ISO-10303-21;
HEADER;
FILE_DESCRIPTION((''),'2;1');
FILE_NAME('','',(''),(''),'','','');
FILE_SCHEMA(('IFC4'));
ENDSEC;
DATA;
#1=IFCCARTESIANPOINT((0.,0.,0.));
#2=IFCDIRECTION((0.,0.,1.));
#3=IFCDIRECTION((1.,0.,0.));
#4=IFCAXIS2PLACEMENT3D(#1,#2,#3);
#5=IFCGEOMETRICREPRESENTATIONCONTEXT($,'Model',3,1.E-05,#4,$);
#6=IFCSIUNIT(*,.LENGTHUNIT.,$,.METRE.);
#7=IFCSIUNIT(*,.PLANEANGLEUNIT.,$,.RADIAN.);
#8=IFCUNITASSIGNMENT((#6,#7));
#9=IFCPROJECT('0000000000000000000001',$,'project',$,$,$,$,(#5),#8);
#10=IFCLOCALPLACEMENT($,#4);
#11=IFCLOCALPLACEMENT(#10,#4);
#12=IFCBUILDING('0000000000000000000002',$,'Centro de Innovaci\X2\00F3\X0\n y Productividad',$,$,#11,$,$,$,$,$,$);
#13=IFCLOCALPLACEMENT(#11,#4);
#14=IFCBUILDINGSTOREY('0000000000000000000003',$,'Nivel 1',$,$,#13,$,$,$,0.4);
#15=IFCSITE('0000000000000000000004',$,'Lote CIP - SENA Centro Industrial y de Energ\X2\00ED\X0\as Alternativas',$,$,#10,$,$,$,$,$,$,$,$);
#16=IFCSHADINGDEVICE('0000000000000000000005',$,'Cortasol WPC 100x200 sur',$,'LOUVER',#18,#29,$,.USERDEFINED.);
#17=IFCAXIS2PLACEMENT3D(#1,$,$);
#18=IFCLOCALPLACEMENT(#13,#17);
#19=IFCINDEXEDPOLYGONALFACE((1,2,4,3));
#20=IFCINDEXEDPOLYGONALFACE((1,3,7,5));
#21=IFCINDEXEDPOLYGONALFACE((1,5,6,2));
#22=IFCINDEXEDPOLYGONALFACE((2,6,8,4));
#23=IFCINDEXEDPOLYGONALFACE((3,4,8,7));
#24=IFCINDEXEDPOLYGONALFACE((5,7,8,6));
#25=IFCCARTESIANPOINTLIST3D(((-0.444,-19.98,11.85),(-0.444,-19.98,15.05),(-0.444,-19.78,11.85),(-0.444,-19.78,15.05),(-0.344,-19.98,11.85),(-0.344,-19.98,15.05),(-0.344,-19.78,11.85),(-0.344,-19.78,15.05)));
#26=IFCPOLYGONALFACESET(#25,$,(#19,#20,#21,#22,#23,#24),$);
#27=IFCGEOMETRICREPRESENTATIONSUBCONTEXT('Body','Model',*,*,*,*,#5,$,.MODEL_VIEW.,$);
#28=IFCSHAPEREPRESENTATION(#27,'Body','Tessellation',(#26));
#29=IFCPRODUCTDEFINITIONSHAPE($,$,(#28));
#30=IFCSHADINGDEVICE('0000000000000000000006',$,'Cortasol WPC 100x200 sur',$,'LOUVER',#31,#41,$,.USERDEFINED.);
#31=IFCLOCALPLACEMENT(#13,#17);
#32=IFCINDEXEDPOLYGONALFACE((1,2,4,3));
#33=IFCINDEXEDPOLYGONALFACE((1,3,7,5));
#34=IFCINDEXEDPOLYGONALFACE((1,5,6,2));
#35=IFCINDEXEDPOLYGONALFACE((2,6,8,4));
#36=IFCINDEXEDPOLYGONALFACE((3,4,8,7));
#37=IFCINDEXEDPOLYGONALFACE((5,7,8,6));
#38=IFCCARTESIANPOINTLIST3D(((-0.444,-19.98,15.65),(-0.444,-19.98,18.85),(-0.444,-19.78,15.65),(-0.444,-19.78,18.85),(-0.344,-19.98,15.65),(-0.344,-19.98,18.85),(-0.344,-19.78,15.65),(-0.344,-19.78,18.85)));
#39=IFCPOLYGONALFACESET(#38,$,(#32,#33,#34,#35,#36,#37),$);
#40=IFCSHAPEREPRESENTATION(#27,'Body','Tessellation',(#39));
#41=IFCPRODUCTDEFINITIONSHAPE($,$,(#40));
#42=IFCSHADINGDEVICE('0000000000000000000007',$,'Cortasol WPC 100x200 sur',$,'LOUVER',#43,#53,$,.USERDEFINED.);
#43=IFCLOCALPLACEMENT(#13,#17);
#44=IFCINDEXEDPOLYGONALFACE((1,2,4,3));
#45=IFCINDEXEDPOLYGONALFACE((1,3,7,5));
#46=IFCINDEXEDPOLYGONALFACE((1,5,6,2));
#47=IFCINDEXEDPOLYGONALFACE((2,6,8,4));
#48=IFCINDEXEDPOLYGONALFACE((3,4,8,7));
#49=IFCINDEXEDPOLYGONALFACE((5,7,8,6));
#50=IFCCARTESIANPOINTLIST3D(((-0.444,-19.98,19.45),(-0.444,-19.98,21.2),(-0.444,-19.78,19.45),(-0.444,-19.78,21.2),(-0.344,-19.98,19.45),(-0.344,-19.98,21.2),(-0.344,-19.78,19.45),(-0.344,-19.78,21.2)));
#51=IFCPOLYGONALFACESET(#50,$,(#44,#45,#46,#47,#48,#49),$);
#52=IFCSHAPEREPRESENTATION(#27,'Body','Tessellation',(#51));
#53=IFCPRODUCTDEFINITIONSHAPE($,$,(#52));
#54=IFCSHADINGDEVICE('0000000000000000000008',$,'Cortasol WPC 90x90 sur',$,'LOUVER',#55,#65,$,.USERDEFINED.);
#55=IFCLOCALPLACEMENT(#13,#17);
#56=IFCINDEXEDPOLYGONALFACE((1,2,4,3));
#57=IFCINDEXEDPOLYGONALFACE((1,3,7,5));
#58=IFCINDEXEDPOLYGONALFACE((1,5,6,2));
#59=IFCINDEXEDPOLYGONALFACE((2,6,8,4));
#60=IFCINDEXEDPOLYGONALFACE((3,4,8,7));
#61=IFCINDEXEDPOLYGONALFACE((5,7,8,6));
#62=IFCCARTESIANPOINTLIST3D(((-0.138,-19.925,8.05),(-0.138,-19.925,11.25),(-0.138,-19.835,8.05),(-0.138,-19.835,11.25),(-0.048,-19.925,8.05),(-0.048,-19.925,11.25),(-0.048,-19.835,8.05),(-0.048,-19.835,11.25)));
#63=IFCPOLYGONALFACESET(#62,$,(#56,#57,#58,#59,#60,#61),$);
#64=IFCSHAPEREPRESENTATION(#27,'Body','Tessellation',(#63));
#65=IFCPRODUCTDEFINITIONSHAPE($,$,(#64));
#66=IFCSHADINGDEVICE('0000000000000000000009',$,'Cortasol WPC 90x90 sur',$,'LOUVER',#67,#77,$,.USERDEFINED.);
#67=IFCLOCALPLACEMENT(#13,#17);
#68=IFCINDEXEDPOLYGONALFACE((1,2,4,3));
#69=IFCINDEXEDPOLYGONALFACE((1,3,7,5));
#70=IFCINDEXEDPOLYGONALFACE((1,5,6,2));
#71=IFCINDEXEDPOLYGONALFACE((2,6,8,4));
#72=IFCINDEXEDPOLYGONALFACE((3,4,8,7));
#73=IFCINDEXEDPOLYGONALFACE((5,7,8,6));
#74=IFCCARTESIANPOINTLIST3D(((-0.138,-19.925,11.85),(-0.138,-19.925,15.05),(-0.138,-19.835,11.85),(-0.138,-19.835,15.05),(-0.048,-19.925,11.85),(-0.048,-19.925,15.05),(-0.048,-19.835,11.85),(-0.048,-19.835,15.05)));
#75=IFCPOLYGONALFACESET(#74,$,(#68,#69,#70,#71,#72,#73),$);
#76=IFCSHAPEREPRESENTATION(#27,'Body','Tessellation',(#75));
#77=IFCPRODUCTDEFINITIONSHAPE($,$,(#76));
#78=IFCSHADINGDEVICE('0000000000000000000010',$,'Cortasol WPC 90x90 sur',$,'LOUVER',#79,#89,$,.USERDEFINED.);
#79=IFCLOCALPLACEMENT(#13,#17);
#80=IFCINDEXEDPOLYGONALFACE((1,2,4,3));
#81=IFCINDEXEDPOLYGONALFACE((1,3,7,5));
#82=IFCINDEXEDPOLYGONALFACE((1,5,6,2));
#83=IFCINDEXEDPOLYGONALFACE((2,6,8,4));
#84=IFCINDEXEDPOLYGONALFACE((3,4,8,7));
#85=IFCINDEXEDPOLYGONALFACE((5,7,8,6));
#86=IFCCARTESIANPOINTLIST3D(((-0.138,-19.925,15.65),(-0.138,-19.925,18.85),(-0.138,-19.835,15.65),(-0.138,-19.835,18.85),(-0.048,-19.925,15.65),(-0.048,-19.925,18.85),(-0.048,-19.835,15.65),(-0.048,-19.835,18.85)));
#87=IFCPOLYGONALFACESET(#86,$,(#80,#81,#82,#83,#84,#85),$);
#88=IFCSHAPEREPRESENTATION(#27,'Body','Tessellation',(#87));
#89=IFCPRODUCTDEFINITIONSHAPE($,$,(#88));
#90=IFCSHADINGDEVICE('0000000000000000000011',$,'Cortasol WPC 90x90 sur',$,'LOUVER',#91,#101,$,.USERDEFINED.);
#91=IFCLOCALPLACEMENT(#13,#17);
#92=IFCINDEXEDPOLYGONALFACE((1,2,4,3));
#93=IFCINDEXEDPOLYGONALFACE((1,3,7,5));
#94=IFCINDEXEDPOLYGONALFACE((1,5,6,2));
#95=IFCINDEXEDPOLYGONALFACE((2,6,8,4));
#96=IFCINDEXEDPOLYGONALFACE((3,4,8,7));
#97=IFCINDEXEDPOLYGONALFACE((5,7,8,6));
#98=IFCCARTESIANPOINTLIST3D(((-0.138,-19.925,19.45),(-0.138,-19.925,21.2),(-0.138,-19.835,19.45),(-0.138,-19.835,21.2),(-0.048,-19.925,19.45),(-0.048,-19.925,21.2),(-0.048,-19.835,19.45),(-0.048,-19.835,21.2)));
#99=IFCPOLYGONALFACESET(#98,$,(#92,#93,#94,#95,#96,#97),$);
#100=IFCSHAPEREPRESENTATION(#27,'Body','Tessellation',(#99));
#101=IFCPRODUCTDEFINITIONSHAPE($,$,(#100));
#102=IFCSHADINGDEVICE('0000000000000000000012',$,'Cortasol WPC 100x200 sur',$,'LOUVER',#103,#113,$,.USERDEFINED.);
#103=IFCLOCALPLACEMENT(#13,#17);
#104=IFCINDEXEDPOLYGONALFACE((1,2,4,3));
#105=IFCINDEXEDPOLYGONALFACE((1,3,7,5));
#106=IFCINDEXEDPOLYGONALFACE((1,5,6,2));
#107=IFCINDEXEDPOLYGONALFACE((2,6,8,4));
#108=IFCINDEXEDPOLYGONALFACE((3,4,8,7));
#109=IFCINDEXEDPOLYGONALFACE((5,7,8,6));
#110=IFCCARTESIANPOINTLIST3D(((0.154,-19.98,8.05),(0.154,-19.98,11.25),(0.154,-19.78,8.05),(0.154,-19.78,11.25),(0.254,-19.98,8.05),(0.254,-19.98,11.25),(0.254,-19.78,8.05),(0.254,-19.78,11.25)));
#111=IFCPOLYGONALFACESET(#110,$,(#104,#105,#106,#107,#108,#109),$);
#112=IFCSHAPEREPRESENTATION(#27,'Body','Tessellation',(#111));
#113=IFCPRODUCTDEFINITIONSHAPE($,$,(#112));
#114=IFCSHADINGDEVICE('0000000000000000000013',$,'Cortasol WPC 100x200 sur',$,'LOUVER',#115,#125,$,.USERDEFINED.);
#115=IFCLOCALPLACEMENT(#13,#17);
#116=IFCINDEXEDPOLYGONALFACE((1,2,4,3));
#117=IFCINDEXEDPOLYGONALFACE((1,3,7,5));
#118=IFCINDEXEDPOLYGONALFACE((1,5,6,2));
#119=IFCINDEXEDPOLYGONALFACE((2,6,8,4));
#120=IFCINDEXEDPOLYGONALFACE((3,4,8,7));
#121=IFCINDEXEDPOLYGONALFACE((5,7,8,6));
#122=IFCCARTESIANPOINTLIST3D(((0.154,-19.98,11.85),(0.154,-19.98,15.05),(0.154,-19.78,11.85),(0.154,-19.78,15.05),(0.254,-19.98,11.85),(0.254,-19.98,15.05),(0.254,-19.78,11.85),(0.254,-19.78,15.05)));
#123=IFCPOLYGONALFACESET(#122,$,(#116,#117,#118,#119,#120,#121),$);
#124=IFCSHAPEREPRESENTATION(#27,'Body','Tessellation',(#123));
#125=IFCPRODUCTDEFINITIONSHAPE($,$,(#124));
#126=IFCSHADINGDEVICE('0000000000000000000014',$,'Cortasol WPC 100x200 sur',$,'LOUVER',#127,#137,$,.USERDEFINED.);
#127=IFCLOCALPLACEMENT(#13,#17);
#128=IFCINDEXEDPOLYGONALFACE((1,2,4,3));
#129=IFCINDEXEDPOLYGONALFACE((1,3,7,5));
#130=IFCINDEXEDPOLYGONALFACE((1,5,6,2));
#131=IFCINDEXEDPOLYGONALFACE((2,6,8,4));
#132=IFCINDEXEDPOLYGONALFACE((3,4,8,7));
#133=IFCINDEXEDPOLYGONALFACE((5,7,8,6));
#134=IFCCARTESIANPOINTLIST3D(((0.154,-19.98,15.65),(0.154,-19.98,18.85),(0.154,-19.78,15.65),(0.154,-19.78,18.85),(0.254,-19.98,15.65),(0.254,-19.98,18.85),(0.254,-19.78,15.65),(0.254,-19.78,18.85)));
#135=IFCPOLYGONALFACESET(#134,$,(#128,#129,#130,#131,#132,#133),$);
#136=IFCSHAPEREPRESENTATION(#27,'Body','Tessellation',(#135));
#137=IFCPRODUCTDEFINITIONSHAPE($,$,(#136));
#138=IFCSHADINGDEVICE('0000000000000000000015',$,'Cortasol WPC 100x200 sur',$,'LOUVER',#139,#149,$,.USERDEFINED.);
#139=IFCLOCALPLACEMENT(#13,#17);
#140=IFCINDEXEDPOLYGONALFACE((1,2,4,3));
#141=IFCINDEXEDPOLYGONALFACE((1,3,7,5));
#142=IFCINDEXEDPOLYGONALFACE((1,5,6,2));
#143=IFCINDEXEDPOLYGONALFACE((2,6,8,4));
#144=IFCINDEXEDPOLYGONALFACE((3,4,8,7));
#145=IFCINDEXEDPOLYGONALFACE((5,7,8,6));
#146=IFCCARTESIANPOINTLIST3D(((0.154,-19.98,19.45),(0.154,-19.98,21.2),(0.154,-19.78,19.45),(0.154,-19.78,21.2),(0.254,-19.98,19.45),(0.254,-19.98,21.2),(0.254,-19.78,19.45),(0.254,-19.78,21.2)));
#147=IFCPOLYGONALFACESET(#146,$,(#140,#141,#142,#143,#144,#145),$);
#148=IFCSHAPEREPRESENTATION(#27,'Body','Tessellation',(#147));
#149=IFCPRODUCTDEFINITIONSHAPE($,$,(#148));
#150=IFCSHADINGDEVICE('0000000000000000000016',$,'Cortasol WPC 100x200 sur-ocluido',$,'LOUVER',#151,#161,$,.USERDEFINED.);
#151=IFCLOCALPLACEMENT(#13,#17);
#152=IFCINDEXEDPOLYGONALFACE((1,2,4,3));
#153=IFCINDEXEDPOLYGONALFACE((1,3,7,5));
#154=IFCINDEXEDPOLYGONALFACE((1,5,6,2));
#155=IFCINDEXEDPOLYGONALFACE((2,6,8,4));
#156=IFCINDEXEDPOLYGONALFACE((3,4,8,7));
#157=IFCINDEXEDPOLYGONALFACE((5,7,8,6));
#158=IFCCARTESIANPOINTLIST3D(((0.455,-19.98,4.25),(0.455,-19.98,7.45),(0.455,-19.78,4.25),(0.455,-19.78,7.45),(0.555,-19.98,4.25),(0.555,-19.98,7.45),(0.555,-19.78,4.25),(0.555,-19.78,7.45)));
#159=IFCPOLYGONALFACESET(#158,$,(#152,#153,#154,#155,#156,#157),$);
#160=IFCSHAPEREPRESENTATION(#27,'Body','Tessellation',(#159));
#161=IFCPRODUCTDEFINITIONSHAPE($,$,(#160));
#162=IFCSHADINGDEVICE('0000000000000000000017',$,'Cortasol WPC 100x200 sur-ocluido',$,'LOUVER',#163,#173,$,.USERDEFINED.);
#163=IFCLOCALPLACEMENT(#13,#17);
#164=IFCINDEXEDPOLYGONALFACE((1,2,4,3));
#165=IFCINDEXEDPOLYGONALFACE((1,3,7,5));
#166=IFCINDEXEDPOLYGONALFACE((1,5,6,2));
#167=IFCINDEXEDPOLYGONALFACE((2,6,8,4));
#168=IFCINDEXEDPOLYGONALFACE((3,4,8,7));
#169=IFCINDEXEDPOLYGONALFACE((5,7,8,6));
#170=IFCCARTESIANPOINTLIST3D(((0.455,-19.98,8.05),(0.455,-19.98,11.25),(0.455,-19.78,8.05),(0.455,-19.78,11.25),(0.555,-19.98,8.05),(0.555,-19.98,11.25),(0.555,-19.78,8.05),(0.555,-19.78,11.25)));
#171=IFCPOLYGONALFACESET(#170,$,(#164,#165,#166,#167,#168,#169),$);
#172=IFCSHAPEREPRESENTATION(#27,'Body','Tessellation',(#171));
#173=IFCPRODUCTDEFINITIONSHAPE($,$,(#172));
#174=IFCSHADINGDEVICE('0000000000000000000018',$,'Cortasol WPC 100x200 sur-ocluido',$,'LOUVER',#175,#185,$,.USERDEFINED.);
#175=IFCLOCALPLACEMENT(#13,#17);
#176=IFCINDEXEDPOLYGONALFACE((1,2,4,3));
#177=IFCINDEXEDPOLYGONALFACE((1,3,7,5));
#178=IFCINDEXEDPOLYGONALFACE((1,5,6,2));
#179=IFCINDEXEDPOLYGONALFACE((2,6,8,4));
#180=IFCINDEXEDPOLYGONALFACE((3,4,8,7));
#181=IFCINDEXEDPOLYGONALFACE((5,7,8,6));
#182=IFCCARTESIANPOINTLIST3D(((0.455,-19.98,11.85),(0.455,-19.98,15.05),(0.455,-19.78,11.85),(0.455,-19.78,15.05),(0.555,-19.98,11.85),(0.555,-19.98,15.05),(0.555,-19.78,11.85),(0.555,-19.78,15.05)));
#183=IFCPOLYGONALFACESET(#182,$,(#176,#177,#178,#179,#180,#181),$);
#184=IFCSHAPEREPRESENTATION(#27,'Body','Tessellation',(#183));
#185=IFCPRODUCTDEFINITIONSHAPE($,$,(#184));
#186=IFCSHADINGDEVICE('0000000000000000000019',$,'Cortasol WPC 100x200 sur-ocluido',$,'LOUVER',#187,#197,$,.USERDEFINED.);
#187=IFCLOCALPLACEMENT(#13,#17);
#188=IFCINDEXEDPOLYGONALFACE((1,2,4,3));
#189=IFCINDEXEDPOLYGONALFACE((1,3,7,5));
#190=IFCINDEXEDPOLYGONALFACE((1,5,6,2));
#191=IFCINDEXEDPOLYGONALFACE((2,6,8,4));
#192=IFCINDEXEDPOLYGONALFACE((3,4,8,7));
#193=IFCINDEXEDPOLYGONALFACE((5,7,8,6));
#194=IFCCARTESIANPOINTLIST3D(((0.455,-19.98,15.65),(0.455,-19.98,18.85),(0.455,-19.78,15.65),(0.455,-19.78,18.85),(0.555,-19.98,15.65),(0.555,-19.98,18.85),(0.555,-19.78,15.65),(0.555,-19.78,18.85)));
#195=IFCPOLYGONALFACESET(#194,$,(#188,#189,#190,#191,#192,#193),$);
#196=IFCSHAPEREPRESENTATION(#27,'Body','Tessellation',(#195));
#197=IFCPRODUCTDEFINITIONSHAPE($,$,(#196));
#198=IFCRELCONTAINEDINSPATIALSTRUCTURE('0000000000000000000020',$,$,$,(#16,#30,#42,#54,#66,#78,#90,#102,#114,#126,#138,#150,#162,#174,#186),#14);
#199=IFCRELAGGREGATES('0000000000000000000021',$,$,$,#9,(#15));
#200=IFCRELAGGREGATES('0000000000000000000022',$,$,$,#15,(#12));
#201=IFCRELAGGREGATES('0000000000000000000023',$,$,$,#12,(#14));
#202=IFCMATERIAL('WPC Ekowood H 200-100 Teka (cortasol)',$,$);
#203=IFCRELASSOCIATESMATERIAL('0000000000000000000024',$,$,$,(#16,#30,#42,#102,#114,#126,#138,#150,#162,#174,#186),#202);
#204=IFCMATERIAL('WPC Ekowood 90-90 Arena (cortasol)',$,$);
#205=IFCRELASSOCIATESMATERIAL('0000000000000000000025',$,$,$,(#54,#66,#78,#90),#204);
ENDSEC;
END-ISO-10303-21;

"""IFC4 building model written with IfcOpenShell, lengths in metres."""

from ifc_helpers import new_model, si_unit, frame, origin_with_axes, place, context, subcontext, project, spatial, polyline, outline, extrude, material, element, save


model = new_model("IFC4")

# Units and contexts
model_context = context("Model", 3, precision=1e-05, world=origin_with_axes())
body_context = subcontext(model_context, "Body", "Model", "MODEL_VIEW")
ifc_project = project(units=[si_unit("LENGTHUNIT", "METRE"), si_unit("PLANEANGLEUNIT", "RADIAN")], contexts=[model_context])

# Site, building, storey
site_placement = place(None, origin_with_axes())
site = spatial("IfcSite", under=ifc_project, at=site_placement, Name="Lote CIP - SENA Centro Industrial y de Energías Alternativas")
building_placement = place(site_placement, origin_with_axes())
building = spatial("IfcBuilding", under=site, at=building_placement, Name="Centro de Innovación y Productividad")
storey_placement = place(building_placement, origin_with_axes())
storey = spatial("IfcBuildingStorey", under=building, at=storey_placement, Name="Nivel 1", Elevation=0.4)

# Shading devices
ifc_material_1 = material(Name="WPC Ekowood H 200-100 Teka (cortasol)")
shading_device_1_placement = place(storey_placement, origin_with_axes())
element("IfcShadingDevice", 1, at=shading_device_1_placement, inside=storey, material=ifc_material_1, Name="Cortasol WPC 100x200 sur", ObjectType="LOUVER", PredefinedType="USERDEFINED", context=body_context, shape_type="SweptSolid", body=[
    extrude(outline(polyline([(-0.444, -19.98), (-0.444, -19.78), (-0.344, -19.78), (-0.344, -19.98), (-0.444, -19.98)])), frame((0.0, 0.0, 11.85)), (0.0, 0.0, 1.0), 3.2),
])
shading_device_2_placement = place(storey_placement, origin_with_axes())
element("IfcShadingDevice", 2, at=shading_device_2_placement, inside=storey, material=ifc_material_1, Name="Cortasol WPC 100x200 sur", ObjectType="LOUVER", PredefinedType="USERDEFINED", context=body_context, shape_type="SweptSolid", body=[
    extrude(outline(polyline([(-0.444, -19.98), (-0.444, -19.78), (-0.344, -19.78), (-0.344, -19.98), (-0.444, -19.98)])), frame((0.0, 0.0, 15.65)), (0.0, 0.0, 1.0), 3.2),
])
shading_device_3_placement = place(storey_placement, origin_with_axes())
element("IfcShadingDevice", 3, at=shading_device_3_placement, inside=storey, material=ifc_material_1, Name="Cortasol WPC 100x200 sur", ObjectType="LOUVER", PredefinedType="USERDEFINED", context=body_context, shape_type="SweptSolid", body=[
    extrude(outline(polyline([(-0.444, -19.98), (-0.444, -19.78), (-0.344, -19.78), (-0.344, -19.98), (-0.444, -19.98)])), frame((0.0, 0.0, 19.45)), (0.0, 0.0, 1.0), 1.75),
])
ifc_material_2 = material(Name="WPC Ekowood 90-90 Arena (cortasol)")
shading_device_4_placement = place(storey_placement, origin_with_axes())
element("IfcShadingDevice", 4, at=shading_device_4_placement, inside=storey, material=ifc_material_2, Name="Cortasol WPC 90x90 sur", ObjectType="LOUVER", PredefinedType="USERDEFINED", context=body_context, shape_type="SweptSolid", body=[
    extrude(outline(polyline([(-0.138, -19.925), (-0.138, -19.835), (-0.048, -19.835), (-0.048, -19.925), (-0.138, -19.925)])), frame((0.0, 0.0, 8.05)), (0.0, 0.0, 1.0), 3.2),
])
shading_device_5_placement = place(storey_placement, origin_with_axes())
element("IfcShadingDevice", 5, at=shading_device_5_placement, inside=storey, material=ifc_material_2, Name="Cortasol WPC 90x90 sur", ObjectType="LOUVER", PredefinedType="USERDEFINED", context=body_context, shape_type="SweptSolid", body=[
    extrude(outline(polyline([(-0.138, -19.925), (-0.138, -19.835), (-0.048, -19.835), (-0.048, -19.925), (-0.138, -19.925)])), frame((0.0, 0.0, 11.85)), (0.0, 0.0, 1.0), 3.2),
])
shading_device_6_placement = place(storey_placement, origin_with_axes())
element("IfcShadingDevice", 6, at=shading_device_6_placement, inside=storey, material=ifc_material_2, Name="Cortasol WPC 90x90 sur", ObjectType="LOUVER", PredefinedType="USERDEFINED", context=body_context, shape_type="SweptSolid", body=[
    extrude(outline(polyline([(-0.138, -19.925), (-0.138, -19.835), (-0.048, -19.835), (-0.048, -19.925), (-0.138, -19.925)])), frame((0.0, 0.0, 15.65)), (0.0, 0.0, 1.0), 3.2),
])
shading_device_7_placement = place(storey_placement, origin_with_axes())
element("IfcShadingDevice", 7, at=shading_device_7_placement, inside=storey, material=ifc_material_2, Name="Cortasol WPC 90x90 sur", ObjectType="LOUVER", PredefinedType="USERDEFINED", context=body_context, shape_type="SweptSolid", body=[
    extrude(outline(polyline([(-0.138, -19.925), (-0.138, -19.835), (-0.048, -19.835), (-0.048, -19.925), (-0.138, -19.925)])), frame((0.0, 0.0, 19.45)), (0.0, 0.0, 1.0), 1.75),
])
shading_device_8_placement = place(storey_placement, origin_with_axes())
element("IfcShadingDevice", 8, at=shading_device_8_placement, inside=storey, material=ifc_material_1, Name="Cortasol WPC 100x200 sur", ObjectType="LOUVER", PredefinedType="USERDEFINED", context=body_context, shape_type="SweptSolid", body=[
    extrude(outline(polyline([(0.154, -19.98), (0.154, -19.78), (0.254, -19.78), (0.254, -19.98), (0.154, -19.98)])), frame((0.0, 0.0, 8.05)), (0.0, 0.0, 1.0), 3.2),
])
shading_device_9_placement = place(storey_placement, origin_with_axes())
element("IfcShadingDevice", 9, at=shading_device_9_placement, inside=storey, material=ifc_material_1, Name="Cortasol WPC 100x200 sur", ObjectType="LOUVER", PredefinedType="USERDEFINED", context=body_context, shape_type="SweptSolid", body=[
    extrude(outline(polyline([(0.154, -19.98), (0.154, -19.78), (0.254, -19.78), (0.254, -19.98), (0.154, -19.98)])), frame((0.0, 0.0, 11.85)), (0.0, 0.0, 1.0), 3.2),
])
shading_device_10_placement = place(storey_placement, origin_with_axes())
element("IfcShadingDevice", 10, at=shading_device_10_placement, inside=storey, material=ifc_material_1, Name="Cortasol WPC 100x200 sur", ObjectType="LOUVER", PredefinedType="USERDEFINED", context=body_context, shape_type="SweptSolid", body=[
    extrude(outline(polyline([(0.154, -19.98), (0.154, -19.78), (0.254, -19.78), (0.254, -19.98), (0.154, -19.98)])), frame((0.0, 0.0, 15.65)), (0.0, 0.0, 1.0), 3.2),
])
shading_device_11_placement = place(storey_placement, origin_with_axes())
element("IfcShadingDevice", 11, at=shading_device_11_placement, inside=storey, material=ifc_material_1, Name="Cortasol WPC 100x200 sur", ObjectType="LOUVER", PredefinedType="USERDEFINED", context=body_context, shape_type="SweptSolid", body=[
    extrude(outline(polyline([(0.154, -19.98), (0.154, -19.78), (0.254, -19.78), (0.254, -19.98), (0.154, -19.98)])), frame((0.0, 0.0, 19.45)), (0.0, 0.0, 1.0), 1.75),
])
shading_device_12_placement = place(storey_placement, origin_with_axes())
element("IfcShadingDevice", 12, at=shading_device_12_placement, inside=storey, material=ifc_material_1, Name="Cortasol WPC 100x200 sur-ocluido", ObjectType="LOUVER", PredefinedType="USERDEFINED", context=body_context, shape_type="SweptSolid", body=[
    extrude(outline(polyline([(0.455, -19.98), (0.455, -19.78), (0.555, -19.78), (0.555, -19.98), (0.455, -19.98)])), frame((0.0, 0.0, 4.25)), (0.0, 0.0, 1.0), 3.2),
])
shading_device_13_placement = place(storey_placement, origin_with_axes())
element("IfcShadingDevice", 13, at=shading_device_13_placement, inside=storey, material=ifc_material_1, Name="Cortasol WPC 100x200 sur-ocluido", ObjectType="LOUVER", PredefinedType="USERDEFINED", context=body_context, shape_type="SweptSolid", body=[
    extrude(outline(polyline([(0.455, -19.98), (0.455, -19.78), (0.555, -19.78), (0.555, -19.98), (0.455, -19.98)])), frame((0.0, 0.0, 8.05)), (0.0, 0.0, 1.0), 3.2),
])
shading_device_14_placement = place(storey_placement, origin_with_axes())
element("IfcShadingDevice", 14, at=shading_device_14_placement, inside=storey, material=ifc_material_1, Name="Cortasol WPC 100x200 sur-ocluido", ObjectType="LOUVER", PredefinedType="USERDEFINED", context=body_context, shape_type="SweptSolid", body=[
    extrude(outline(polyline([(0.455, -19.98), (0.455, -19.78), (0.555, -19.78), (0.555, -19.98), (0.455, -19.98)])), frame((0.0, 0.0, 11.85)), (0.0, 0.0, 1.0), 3.2),
])
shading_device_15_placement = place(storey_placement, origin_with_axes())
element("IfcShadingDevice", 15, at=shading_device_15_placement, inside=storey, material=ifc_material_1, Name="Cortasol WPC 100x200 sur-ocluido", ObjectType="LOUVER", PredefinedType="USERDEFINED", context=body_context, shape_type="SweptSolid", body=[
    extrude(outline(polyline([(0.455, -19.98), (0.455, -19.78), (0.555, -19.78), (0.555, -19.98), (0.455, -19.98)])), frame((0.0, 0.0, 15.65)), (0.0, 0.0, 1.0), 3.2),
])

save(model, "model.ifc")
